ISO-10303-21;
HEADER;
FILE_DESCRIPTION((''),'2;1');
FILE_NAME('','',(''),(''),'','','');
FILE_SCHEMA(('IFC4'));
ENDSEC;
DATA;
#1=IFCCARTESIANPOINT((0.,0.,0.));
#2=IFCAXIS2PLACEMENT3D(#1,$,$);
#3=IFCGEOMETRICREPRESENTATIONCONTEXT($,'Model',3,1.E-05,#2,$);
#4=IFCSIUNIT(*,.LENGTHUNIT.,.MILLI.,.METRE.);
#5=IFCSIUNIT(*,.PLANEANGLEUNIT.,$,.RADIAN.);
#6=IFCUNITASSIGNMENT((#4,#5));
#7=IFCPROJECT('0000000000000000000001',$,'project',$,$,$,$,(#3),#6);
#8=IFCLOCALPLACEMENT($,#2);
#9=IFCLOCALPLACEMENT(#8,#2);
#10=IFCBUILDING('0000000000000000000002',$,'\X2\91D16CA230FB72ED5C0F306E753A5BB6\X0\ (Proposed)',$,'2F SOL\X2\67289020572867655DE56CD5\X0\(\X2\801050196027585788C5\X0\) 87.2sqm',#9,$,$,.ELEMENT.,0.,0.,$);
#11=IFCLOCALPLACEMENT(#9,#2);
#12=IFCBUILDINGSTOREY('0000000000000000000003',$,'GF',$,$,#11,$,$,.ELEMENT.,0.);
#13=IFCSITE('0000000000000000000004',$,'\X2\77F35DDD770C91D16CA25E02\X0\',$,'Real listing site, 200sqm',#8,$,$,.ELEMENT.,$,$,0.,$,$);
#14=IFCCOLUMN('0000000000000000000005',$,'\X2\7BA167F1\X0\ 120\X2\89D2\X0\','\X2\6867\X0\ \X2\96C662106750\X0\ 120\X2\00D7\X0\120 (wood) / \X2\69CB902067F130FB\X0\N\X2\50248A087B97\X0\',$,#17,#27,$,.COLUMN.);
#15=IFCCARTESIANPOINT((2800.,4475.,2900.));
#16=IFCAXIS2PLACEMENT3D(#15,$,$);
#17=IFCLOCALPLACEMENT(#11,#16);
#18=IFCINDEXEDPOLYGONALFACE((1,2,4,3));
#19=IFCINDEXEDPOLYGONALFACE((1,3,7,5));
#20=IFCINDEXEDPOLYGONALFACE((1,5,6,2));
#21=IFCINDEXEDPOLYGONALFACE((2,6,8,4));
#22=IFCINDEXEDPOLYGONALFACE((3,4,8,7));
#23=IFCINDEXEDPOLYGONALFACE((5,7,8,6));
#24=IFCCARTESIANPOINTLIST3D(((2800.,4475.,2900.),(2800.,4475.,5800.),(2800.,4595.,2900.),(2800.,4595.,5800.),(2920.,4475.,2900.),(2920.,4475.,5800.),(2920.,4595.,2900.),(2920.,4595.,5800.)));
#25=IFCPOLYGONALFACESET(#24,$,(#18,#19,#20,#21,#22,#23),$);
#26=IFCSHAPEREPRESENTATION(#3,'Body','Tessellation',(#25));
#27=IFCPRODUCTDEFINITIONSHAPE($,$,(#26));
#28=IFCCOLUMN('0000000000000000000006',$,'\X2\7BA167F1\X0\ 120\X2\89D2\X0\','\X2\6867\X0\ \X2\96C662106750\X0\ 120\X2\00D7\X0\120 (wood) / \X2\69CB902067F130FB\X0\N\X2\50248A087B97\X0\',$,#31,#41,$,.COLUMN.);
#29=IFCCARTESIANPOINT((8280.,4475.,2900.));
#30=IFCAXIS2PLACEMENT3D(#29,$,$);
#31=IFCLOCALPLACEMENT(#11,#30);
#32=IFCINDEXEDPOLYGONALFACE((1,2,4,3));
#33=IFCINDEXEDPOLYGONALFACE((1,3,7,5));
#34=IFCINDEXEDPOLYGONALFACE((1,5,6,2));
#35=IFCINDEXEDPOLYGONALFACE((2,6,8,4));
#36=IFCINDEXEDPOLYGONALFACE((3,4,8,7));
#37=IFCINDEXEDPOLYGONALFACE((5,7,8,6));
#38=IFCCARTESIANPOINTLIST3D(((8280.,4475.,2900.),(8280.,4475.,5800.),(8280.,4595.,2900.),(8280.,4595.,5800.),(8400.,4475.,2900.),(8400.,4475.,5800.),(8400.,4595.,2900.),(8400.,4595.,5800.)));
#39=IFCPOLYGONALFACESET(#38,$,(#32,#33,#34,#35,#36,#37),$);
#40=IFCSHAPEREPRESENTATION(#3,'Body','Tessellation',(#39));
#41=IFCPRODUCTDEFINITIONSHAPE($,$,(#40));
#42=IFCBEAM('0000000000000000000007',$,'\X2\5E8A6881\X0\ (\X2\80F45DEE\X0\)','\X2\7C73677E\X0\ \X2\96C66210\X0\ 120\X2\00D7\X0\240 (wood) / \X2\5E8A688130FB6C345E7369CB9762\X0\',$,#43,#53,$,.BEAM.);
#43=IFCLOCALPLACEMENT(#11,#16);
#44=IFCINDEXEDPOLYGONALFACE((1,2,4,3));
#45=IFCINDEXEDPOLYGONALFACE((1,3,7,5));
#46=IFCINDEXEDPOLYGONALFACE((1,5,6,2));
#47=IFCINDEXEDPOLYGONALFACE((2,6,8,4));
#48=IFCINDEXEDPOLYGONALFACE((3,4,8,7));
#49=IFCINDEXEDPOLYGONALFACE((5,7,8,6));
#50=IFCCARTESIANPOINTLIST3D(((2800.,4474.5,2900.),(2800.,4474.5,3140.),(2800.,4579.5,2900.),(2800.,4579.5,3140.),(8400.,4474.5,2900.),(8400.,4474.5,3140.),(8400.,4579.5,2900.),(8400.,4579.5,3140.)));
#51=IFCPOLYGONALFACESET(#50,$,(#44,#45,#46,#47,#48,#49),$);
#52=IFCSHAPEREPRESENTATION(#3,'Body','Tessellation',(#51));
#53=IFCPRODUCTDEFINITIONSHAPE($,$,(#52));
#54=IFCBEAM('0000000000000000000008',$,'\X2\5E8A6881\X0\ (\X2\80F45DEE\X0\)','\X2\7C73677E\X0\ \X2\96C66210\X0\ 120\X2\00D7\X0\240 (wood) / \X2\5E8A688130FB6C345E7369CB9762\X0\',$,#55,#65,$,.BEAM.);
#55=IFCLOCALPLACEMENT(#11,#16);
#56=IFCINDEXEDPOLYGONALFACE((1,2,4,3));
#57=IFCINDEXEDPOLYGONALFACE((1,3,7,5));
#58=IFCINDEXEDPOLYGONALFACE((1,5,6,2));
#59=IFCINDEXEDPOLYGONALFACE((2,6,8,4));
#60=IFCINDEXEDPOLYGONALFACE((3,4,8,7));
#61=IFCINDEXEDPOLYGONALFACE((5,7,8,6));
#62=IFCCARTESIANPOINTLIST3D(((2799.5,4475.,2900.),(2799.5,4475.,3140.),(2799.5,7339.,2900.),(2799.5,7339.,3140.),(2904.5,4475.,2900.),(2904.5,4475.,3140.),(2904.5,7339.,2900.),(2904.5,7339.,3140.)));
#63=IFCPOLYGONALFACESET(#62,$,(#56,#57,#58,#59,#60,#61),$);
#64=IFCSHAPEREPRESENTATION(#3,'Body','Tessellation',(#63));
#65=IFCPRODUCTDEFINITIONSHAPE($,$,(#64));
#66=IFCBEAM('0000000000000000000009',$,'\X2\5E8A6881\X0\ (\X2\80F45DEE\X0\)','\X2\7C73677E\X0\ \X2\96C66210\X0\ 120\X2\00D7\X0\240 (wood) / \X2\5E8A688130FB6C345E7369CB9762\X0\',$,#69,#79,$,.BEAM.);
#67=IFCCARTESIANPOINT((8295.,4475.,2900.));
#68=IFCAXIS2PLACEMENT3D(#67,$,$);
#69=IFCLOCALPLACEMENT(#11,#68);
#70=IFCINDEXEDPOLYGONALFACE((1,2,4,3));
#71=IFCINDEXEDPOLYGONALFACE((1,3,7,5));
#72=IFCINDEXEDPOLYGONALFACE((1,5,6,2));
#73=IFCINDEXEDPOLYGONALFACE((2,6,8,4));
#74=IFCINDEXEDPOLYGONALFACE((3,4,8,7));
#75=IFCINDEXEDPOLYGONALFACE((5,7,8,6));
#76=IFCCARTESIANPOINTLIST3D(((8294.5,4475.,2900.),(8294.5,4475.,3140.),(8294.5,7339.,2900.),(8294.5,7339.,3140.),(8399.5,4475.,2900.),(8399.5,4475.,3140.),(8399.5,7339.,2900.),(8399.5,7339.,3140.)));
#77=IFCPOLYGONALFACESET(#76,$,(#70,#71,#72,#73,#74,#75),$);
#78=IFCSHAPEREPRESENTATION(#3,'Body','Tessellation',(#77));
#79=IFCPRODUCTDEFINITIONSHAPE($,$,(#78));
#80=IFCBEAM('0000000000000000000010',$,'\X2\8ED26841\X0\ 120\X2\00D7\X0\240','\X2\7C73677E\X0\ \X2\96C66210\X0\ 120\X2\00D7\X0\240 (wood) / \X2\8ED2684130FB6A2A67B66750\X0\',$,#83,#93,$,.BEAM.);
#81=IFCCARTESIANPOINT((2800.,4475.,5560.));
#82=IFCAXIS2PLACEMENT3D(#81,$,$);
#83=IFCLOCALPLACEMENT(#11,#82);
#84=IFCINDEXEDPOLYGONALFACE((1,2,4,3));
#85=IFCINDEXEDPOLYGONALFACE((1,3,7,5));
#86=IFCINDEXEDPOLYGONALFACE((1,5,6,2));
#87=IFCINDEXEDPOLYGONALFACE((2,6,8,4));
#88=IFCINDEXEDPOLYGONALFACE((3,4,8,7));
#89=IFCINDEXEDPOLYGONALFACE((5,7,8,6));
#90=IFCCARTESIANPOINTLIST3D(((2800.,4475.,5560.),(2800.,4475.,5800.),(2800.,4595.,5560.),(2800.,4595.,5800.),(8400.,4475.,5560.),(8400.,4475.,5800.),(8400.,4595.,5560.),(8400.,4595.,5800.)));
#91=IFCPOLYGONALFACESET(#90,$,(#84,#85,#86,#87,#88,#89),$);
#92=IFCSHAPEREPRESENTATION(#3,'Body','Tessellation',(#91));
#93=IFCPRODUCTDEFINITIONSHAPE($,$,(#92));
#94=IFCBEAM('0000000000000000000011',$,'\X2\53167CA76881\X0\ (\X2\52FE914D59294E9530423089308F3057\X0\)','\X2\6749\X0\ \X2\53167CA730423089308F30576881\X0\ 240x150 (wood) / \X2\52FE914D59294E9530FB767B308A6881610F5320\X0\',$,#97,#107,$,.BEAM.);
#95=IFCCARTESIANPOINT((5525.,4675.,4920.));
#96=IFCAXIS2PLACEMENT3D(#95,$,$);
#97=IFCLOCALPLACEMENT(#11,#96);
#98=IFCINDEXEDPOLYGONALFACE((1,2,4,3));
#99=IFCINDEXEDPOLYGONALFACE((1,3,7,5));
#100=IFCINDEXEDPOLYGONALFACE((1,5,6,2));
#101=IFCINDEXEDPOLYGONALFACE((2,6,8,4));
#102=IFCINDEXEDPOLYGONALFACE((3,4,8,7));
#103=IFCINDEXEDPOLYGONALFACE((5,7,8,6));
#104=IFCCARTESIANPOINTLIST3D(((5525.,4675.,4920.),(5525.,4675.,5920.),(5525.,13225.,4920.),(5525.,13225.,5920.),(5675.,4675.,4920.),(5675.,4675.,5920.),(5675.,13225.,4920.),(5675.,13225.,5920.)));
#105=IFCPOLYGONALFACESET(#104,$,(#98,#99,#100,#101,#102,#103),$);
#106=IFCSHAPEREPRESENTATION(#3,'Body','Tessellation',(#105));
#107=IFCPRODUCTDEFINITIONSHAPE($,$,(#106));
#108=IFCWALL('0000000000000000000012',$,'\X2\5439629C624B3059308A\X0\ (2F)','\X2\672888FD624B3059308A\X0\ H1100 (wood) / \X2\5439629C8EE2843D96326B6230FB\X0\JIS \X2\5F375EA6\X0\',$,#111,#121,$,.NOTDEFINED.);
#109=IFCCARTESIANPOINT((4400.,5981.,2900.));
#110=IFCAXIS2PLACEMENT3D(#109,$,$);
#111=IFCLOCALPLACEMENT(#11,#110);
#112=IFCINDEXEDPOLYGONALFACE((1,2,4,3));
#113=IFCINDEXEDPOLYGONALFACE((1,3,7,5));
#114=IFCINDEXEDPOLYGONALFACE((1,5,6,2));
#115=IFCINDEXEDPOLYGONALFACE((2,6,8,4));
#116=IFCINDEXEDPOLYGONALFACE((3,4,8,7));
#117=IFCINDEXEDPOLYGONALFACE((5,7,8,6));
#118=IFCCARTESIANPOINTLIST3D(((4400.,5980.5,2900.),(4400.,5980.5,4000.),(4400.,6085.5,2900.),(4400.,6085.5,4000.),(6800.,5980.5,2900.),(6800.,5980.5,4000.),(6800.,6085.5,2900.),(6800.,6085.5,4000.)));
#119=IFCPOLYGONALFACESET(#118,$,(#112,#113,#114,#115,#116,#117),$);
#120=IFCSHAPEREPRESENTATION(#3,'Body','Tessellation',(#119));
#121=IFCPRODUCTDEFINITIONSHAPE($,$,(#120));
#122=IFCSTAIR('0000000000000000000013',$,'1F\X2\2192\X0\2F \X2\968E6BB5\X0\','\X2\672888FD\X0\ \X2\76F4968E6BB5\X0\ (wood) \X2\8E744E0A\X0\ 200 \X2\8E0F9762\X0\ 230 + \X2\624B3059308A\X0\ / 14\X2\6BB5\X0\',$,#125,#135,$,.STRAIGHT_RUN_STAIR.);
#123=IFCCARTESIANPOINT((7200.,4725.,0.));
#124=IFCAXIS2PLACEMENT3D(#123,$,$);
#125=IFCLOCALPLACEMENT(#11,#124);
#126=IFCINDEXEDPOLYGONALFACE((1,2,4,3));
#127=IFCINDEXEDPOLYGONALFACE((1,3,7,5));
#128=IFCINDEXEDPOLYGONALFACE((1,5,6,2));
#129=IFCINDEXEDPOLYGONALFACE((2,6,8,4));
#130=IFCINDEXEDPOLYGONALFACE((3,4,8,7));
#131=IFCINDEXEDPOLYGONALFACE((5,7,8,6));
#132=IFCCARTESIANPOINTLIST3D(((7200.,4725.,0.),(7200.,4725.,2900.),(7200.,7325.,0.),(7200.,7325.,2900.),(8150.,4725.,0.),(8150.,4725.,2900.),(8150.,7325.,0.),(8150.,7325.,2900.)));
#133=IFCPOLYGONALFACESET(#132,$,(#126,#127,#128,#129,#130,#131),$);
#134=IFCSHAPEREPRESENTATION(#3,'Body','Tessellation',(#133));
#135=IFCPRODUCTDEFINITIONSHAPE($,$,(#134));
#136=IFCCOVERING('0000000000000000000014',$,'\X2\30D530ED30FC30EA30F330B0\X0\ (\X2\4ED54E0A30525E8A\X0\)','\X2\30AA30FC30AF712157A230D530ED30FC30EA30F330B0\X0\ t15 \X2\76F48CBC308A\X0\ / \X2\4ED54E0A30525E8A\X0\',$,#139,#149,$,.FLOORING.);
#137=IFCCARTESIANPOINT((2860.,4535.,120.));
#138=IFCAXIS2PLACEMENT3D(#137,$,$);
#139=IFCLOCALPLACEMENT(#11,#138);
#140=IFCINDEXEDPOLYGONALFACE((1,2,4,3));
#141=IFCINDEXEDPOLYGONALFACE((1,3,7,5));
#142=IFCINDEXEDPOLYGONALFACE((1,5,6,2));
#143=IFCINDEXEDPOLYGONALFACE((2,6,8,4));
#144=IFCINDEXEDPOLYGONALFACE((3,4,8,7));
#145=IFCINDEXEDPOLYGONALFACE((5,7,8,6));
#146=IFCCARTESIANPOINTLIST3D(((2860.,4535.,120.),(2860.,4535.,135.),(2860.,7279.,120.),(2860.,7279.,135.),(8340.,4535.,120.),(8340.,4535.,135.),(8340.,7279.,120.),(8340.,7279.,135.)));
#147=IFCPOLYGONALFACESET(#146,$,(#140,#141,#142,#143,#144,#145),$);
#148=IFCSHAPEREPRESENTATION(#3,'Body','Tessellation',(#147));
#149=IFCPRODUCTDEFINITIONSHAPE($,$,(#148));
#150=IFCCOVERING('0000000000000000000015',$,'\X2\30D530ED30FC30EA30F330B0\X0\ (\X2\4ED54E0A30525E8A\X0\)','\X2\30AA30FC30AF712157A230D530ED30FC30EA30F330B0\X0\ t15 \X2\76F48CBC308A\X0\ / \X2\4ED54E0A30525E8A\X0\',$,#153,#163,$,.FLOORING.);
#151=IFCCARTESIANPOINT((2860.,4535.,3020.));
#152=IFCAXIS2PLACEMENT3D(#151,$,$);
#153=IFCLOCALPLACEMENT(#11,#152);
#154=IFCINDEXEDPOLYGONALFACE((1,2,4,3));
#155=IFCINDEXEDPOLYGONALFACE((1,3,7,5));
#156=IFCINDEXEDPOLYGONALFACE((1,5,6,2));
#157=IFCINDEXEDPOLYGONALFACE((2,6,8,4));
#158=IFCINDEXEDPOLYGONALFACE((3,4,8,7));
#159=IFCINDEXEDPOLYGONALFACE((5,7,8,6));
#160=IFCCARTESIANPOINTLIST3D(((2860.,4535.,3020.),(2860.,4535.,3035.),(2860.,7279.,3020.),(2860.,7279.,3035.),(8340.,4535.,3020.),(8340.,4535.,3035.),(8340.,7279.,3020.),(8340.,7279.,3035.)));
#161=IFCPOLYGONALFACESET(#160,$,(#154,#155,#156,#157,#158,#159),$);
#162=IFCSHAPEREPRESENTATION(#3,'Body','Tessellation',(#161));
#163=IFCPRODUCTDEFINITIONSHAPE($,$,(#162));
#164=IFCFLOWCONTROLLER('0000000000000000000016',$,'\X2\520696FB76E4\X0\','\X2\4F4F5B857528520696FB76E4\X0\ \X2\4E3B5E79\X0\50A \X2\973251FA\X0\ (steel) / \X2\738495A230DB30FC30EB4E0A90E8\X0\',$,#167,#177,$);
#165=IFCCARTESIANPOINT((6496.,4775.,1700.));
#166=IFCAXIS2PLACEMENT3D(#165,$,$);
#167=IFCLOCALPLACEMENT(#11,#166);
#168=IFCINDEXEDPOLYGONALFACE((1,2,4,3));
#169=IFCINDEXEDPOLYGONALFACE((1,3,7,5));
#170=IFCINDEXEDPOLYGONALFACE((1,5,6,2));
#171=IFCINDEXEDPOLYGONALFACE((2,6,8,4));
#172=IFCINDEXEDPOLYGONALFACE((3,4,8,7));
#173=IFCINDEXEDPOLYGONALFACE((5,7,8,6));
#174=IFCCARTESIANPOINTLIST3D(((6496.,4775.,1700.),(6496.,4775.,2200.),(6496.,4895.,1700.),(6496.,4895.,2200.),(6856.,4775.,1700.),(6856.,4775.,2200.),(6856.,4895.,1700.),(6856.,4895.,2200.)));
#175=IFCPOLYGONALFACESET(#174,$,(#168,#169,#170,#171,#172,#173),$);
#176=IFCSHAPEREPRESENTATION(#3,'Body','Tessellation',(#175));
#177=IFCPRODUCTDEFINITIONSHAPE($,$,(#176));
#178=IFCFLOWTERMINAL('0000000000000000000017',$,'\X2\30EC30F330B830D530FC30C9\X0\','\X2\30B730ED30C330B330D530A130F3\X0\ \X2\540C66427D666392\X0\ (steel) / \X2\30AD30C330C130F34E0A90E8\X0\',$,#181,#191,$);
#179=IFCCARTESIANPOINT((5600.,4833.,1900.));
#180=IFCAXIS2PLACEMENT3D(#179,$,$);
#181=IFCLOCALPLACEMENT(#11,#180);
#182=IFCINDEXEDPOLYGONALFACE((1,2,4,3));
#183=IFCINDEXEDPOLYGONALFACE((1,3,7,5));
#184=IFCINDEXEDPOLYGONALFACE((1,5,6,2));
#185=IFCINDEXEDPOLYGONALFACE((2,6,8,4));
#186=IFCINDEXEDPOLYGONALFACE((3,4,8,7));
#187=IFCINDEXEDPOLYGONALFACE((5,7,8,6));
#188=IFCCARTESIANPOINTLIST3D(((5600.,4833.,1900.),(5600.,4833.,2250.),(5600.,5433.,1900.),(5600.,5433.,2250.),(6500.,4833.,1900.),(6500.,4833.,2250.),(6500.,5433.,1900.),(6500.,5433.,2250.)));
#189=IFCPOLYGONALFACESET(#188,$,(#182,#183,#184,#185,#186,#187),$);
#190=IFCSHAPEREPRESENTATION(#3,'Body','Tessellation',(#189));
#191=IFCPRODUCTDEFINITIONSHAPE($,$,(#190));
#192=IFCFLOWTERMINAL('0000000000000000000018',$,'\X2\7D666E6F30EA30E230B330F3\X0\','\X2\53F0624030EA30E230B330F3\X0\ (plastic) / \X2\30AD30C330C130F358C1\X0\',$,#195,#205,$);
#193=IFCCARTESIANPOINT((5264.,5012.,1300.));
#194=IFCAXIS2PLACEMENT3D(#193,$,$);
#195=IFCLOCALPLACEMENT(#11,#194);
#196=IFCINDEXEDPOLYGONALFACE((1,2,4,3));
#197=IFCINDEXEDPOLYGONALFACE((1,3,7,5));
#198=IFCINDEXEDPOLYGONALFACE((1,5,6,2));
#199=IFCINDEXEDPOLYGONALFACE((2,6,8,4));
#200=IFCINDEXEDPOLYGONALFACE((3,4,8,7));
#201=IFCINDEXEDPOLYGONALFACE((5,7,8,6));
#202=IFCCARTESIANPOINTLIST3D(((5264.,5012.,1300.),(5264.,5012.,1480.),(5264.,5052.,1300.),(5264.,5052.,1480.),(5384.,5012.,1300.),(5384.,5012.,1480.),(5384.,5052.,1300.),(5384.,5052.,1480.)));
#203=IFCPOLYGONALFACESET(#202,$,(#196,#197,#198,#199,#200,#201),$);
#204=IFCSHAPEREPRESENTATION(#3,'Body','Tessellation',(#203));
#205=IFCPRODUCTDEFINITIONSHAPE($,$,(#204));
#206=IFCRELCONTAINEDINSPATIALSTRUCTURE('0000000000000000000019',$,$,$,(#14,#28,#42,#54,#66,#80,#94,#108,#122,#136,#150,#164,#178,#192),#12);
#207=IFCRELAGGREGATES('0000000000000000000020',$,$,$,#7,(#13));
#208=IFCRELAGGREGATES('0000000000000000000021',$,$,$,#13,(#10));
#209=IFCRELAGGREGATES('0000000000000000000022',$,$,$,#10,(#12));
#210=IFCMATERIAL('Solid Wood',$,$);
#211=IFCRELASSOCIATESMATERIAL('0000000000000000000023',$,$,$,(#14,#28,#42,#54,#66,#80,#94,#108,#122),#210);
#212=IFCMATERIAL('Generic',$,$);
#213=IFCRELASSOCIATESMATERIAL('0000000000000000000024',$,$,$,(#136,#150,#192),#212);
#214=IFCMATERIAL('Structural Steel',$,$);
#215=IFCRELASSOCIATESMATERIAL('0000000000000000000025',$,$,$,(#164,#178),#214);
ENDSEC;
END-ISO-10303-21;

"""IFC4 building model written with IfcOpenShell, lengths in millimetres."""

from ifc_helpers import new_model, si_unit, frame, frame_2d, origin, place, context, project, spatial, rectangle, extrude, material, element, save


model = new_model("IFC4")

# Units and contexts
model_context = context("Model", 3, precision=1e-05, world=origin())
ifc_project = project(units=[si_unit("LENGTHUNIT", "METRE", prefix="MILLI"), si_unit("PLANEANGLEUNIT", "RADIAN")], contexts=[model_context])

# Site, building, storey
site_placement = place(None, origin())
site = spatial("IfcSite", under=ifc_project, at=site_placement, Name="石川県金沢市", ObjectType="Real listing site, 200sqm", CompositionType="ELEMENT", RefElevation=0.0)
building_placement = place(site_placement, origin())
building = spatial("IfcBuilding", under=site, at=building_placement, Name="金沢・狭小の町家 (Proposed)", ObjectType="2F SOL木造在来工法(耐候性塗装) 87.2sqm", CompositionType="ELEMENT", ElevationOfRefHeight=0.0, ElevationOfTerrain=0.0)
storey_placement = place(building_placement, origin())
storey = spatial("IfcBuildingStorey", under=building, at=storey_placement, Name="GF", CompositionType="ELEMENT", Elevation=0.0)

# Columns
ifc_material_1 = material(Name="Solid Wood")
column_1_placement = place(storey_placement, frame((2800.0, 4475.0, 2900.0)))
element("IfcColumn", 1, at=column_1_placement, inside=storey, material=ifc_material_1, Name="管柱 120角", Description="桧 集成材 120×120 (wood) / 構造柱・N値計算", PredefinedType="COLUMN", context=model_context, shape_type="SweptSolid", body=[
    extrude(rectangle(XDim=120.0, YDim=120.0, at=frame_2d((60.0, 60.0))), frame((2800.0, 4475.0, 2900.0)), (0.0, 0.0, 1.0), 2900.0),
])
column_2_placement = place(storey_placement, frame((8280.0, 4475.0, 2900.0)))
element("IfcColumn", 2, at=column_2_placement, inside=storey, material=ifc_material_1, Name="管柱 120角", Description="桧 集成材 120×120 (wood) / 構造柱・N値計算", PredefinedType="COLUMN", context=model_context, shape_type="SweptSolid", body=[
    extrude(rectangle(XDim=120.0, YDim=120.0, at=frame_2d((60.0, 60.0))), frame((8280.0, 4475.0, 2900.0)), (0.0, 0.0, 1.0), 2900.0),
])

# Beams
beam_1_placement = place(storey_placement, frame((2800.0, 4475.0, 2900.0)))
element("IfcBeam", 3, at=beam_1_placement, inside=storey, material=ifc_material_1, Name="床梁 (胴差)", Description="米松 集成 120×240 (wood) / 床梁・水平構面", PredefinedType="BEAM", context=model_context, shape_type="SweptSolid", body=[
    extrude(rectangle(XDim=5600.0, YDim=105.0, at=frame_2d((2800.0, 52.0))), frame((2800.0, 4475.0, 2900.0)), (0.0, 0.0, 1.0), 240.0),
])
beam_2_placement = place(storey_placement, frame((2800.0, 4475.0, 2900.0)))
element("IfcBeam", 4, at=beam_2_placement, inside=storey, material=ifc_material_1, Name="床梁 (胴差)", Description="米松 集成 120×240 (wood) / 床梁・水平構面", PredefinedType="BEAM", context=model_context, shape_type="SweptSolid", body=[
    extrude(rectangle(XDim=105.0, YDim=2864.0, at=frame_2d((52.0, 1432.0))), frame((2800.0, 4475.0, 2900.0)), (0.0, 0.0, 1.0), 240.0),
])
beam_3_placement = place(storey_placement, frame((8295.0, 4475.0, 2900.0)))
element("IfcBeam", 5, at=beam_3_placement, inside=storey, material=ifc_material_1, Name="床梁 (胴差)", Description="米松 集成 120×240 (wood) / 床梁・水平構面", PredefinedType="BEAM", context=model_context, shape_type="SweptSolid", body=[
    extrude(rectangle(XDim=105.0, YDim=2864.0, at=frame_2d((52.0, 1432.0))), frame((8295.0, 4475.0, 2900.0)), (0.0, 0.0, 1.0), 240.0),
])
beam_4_placement = place(storey_placement, frame((2800.0, 4475.0, 5560.0)))
element("IfcBeam", 6, at=beam_4_placement, inside=storey, material=ifc_material_1, Name="軒桁 120×240", Description="米松 集成 120×240 (wood) / 軒桁・横架材", PredefinedType="BEAM", context=model_context, shape_type="SweptSolid", body=[
    extrude(rectangle(XDim=5600.0, YDim=120.0, at=frame_2d((2800.0, 60.0))), frame((2800.0, 4475.0, 5560.0)), (0.0, 0.0, 1.0), 240.0),
])
beam_5_placement = place(storey_placement, frame((5525.0, 4675.0, 4920.0)))
element("IfcBeam", 7, at=beam_5_placement, inside=storey, material=ifc_material_1, Name="化粧梁 (勾配天井あらわし)", Description="杉 化粧あらわし梁 240x150 (wood) / 勾配天井・登り梁意匠", PredefinedType="BEAM", context=model_context, shape_type="SweptSolid", body=[
    extrude(rectangle(XDim=150.0, YDim=8550.0, at=frame_2d((75.0, 4275.0))), frame((5525.0, 4675.0, 4920.0)), (0.0, 0.0, 1.0), 1000.0),
])

# Wall
wall_1_placement = place(storey_placement, frame((4400.0, 5981.0, 2900.0)))
element("IfcWall", 8, at=wall_1_placement, inside=storey, material=ifc_material_1, Name="吹抜手すり (2F)", Description="木製手すり H1100 (wood) / 吹抜転落防止・JIS 強度", PredefinedType="NOTDEFINED", context=model_context, shape_type="SweptSolid", body=[
    extrude(rectangle(XDim=2400.0, YDim=105.0, at=frame_2d((1200.0, 52.0))), frame((4400.0, 5981.0, 2900.0)), (0.0, 0.0, 1.0), 1100.0),
])

# Stair
stair_placement = place(storey_placement, frame((7200.0, 4725.0, 0.0)))
element("IfcStair", 9, at=stair_placement, inside=storey, material=ifc_material_1, Name="1F→2F 階段", Description="木製 直階段 (wood) 蹴上 200 踏面 230 + 手すり / 14段", PredefinedType="STRAIGHT_RUN_STAIR", context=model_context, shape_type="SweptSolid", body=[
    extrude(rectangle(XDim=950.0, YDim=2600.0, at=frame_2d((475.0, 1300.0))), frame((7200.0, 4725.0, 0.0)), (0.0, 0.0, 1.0), 2900.0),
])

# Coverings
ifc_material_2 = material(Name="Generic")
covering_1_placement = place(storey_placement, frame((2860.0, 4535.0, 120.0)))
element("IfcCovering", 10, at=covering_1_placement, inside=storey, material=ifc_material_2, Name="フローリング (仕上げ床)", Description="オーク無垢フローリング t15 直貼り / 仕上げ床", PredefinedType="FLOORING", context=model_context, shape_type="SweptSolid", body=[
    extrude(rectangle(XDim=5480.0, YDim=2744.0, at=frame_2d((2740.0, 1372.0))), frame((2860.0, 4535.0, 120.0)), (0.0, 0.0, 1.0), 15.0),
])
covering_2_placement = place(storey_placement, frame((2860.0, 4535.0, 3020.0)))
element("IfcCovering", 11, at=covering_2_placement, inside=storey, material=ifc_material_2, Name="フローリング (仕上げ床)", Description="オーク無垢フローリング t15 直貼り / 仕上げ床", PredefinedType="FLOORING", context=model_context, shape_type="SweptSolid", body=[
    extrude(rectangle(XDim=5480.0, YDim=2744.0, at=frame_2d((2740.0, 1372.0))), frame((2860.0, 4535.0, 3020.0)), (0.0, 0.0, 1.0), 15.0),
])

# Flow controller
ifc_material_3 = material(Name="Structural Steel")
flow_controller_placement = place(storey_placement, frame((6496.0, 4775.0, 1700.0)))
element("IfcFlowController", 12, at=flow_controller_placement, inside=storey, material=ifc_material_3, Name="分電盤", Description="住宅用分電盤 主幹50A 露出 (steel) / 玄関ホール上部", context=model_context, shape_type="SweptSolid", body=[
    extrude(rectangle(XDim=360.0, YDim=120.0, at=frame_2d((180.0, 60.0))), frame((6496.0, 4775.0, 1700.0)), (0.0, 0.0, 1.0), 500.0),
])

# Flow terminals
flow_terminal_1_placement = place(storey_placement, frame((5600.0, 4833.0, 1900.0)))
element("IfcFlowTerminal", 13, at=flow_terminal_1_placement, inside=storey, material=ifc_material_3, Name="レンジフード", Description="シロッコファン 同時給排 (steel) / キッチン上部", context=model_context, shape_type="SweptSolid", body=[
    extrude(rectangle(XDim=900.0, YDim=600.0, at=frame_2d((450.0, 300.0))), frame((5600.0, 4833.0, 1900.0)), (0.0, 0.0, 1.0), 350.0),
])
flow_terminal_2_placement = place(storey_placement, frame((5264.0, 5012.0, 1300.0)))
element("IfcFlowTerminal", 14, at=flow_terminal_2_placement, inside=storey, material=ifc_material_2, Name="給湯リモコン", Description="台所リモコン (plastic) / キッチン壁", context=model_context, shape_type="SweptSolid", body=[
    extrude(rectangle(XDim=120.0, YDim=40.0, at=frame_2d((60.0, 20.0))), frame((5264.0, 5012.0, 1300.0)), (0.0, 0.0, 1.0), 180.0),
])

save(model, "model.ifc")
